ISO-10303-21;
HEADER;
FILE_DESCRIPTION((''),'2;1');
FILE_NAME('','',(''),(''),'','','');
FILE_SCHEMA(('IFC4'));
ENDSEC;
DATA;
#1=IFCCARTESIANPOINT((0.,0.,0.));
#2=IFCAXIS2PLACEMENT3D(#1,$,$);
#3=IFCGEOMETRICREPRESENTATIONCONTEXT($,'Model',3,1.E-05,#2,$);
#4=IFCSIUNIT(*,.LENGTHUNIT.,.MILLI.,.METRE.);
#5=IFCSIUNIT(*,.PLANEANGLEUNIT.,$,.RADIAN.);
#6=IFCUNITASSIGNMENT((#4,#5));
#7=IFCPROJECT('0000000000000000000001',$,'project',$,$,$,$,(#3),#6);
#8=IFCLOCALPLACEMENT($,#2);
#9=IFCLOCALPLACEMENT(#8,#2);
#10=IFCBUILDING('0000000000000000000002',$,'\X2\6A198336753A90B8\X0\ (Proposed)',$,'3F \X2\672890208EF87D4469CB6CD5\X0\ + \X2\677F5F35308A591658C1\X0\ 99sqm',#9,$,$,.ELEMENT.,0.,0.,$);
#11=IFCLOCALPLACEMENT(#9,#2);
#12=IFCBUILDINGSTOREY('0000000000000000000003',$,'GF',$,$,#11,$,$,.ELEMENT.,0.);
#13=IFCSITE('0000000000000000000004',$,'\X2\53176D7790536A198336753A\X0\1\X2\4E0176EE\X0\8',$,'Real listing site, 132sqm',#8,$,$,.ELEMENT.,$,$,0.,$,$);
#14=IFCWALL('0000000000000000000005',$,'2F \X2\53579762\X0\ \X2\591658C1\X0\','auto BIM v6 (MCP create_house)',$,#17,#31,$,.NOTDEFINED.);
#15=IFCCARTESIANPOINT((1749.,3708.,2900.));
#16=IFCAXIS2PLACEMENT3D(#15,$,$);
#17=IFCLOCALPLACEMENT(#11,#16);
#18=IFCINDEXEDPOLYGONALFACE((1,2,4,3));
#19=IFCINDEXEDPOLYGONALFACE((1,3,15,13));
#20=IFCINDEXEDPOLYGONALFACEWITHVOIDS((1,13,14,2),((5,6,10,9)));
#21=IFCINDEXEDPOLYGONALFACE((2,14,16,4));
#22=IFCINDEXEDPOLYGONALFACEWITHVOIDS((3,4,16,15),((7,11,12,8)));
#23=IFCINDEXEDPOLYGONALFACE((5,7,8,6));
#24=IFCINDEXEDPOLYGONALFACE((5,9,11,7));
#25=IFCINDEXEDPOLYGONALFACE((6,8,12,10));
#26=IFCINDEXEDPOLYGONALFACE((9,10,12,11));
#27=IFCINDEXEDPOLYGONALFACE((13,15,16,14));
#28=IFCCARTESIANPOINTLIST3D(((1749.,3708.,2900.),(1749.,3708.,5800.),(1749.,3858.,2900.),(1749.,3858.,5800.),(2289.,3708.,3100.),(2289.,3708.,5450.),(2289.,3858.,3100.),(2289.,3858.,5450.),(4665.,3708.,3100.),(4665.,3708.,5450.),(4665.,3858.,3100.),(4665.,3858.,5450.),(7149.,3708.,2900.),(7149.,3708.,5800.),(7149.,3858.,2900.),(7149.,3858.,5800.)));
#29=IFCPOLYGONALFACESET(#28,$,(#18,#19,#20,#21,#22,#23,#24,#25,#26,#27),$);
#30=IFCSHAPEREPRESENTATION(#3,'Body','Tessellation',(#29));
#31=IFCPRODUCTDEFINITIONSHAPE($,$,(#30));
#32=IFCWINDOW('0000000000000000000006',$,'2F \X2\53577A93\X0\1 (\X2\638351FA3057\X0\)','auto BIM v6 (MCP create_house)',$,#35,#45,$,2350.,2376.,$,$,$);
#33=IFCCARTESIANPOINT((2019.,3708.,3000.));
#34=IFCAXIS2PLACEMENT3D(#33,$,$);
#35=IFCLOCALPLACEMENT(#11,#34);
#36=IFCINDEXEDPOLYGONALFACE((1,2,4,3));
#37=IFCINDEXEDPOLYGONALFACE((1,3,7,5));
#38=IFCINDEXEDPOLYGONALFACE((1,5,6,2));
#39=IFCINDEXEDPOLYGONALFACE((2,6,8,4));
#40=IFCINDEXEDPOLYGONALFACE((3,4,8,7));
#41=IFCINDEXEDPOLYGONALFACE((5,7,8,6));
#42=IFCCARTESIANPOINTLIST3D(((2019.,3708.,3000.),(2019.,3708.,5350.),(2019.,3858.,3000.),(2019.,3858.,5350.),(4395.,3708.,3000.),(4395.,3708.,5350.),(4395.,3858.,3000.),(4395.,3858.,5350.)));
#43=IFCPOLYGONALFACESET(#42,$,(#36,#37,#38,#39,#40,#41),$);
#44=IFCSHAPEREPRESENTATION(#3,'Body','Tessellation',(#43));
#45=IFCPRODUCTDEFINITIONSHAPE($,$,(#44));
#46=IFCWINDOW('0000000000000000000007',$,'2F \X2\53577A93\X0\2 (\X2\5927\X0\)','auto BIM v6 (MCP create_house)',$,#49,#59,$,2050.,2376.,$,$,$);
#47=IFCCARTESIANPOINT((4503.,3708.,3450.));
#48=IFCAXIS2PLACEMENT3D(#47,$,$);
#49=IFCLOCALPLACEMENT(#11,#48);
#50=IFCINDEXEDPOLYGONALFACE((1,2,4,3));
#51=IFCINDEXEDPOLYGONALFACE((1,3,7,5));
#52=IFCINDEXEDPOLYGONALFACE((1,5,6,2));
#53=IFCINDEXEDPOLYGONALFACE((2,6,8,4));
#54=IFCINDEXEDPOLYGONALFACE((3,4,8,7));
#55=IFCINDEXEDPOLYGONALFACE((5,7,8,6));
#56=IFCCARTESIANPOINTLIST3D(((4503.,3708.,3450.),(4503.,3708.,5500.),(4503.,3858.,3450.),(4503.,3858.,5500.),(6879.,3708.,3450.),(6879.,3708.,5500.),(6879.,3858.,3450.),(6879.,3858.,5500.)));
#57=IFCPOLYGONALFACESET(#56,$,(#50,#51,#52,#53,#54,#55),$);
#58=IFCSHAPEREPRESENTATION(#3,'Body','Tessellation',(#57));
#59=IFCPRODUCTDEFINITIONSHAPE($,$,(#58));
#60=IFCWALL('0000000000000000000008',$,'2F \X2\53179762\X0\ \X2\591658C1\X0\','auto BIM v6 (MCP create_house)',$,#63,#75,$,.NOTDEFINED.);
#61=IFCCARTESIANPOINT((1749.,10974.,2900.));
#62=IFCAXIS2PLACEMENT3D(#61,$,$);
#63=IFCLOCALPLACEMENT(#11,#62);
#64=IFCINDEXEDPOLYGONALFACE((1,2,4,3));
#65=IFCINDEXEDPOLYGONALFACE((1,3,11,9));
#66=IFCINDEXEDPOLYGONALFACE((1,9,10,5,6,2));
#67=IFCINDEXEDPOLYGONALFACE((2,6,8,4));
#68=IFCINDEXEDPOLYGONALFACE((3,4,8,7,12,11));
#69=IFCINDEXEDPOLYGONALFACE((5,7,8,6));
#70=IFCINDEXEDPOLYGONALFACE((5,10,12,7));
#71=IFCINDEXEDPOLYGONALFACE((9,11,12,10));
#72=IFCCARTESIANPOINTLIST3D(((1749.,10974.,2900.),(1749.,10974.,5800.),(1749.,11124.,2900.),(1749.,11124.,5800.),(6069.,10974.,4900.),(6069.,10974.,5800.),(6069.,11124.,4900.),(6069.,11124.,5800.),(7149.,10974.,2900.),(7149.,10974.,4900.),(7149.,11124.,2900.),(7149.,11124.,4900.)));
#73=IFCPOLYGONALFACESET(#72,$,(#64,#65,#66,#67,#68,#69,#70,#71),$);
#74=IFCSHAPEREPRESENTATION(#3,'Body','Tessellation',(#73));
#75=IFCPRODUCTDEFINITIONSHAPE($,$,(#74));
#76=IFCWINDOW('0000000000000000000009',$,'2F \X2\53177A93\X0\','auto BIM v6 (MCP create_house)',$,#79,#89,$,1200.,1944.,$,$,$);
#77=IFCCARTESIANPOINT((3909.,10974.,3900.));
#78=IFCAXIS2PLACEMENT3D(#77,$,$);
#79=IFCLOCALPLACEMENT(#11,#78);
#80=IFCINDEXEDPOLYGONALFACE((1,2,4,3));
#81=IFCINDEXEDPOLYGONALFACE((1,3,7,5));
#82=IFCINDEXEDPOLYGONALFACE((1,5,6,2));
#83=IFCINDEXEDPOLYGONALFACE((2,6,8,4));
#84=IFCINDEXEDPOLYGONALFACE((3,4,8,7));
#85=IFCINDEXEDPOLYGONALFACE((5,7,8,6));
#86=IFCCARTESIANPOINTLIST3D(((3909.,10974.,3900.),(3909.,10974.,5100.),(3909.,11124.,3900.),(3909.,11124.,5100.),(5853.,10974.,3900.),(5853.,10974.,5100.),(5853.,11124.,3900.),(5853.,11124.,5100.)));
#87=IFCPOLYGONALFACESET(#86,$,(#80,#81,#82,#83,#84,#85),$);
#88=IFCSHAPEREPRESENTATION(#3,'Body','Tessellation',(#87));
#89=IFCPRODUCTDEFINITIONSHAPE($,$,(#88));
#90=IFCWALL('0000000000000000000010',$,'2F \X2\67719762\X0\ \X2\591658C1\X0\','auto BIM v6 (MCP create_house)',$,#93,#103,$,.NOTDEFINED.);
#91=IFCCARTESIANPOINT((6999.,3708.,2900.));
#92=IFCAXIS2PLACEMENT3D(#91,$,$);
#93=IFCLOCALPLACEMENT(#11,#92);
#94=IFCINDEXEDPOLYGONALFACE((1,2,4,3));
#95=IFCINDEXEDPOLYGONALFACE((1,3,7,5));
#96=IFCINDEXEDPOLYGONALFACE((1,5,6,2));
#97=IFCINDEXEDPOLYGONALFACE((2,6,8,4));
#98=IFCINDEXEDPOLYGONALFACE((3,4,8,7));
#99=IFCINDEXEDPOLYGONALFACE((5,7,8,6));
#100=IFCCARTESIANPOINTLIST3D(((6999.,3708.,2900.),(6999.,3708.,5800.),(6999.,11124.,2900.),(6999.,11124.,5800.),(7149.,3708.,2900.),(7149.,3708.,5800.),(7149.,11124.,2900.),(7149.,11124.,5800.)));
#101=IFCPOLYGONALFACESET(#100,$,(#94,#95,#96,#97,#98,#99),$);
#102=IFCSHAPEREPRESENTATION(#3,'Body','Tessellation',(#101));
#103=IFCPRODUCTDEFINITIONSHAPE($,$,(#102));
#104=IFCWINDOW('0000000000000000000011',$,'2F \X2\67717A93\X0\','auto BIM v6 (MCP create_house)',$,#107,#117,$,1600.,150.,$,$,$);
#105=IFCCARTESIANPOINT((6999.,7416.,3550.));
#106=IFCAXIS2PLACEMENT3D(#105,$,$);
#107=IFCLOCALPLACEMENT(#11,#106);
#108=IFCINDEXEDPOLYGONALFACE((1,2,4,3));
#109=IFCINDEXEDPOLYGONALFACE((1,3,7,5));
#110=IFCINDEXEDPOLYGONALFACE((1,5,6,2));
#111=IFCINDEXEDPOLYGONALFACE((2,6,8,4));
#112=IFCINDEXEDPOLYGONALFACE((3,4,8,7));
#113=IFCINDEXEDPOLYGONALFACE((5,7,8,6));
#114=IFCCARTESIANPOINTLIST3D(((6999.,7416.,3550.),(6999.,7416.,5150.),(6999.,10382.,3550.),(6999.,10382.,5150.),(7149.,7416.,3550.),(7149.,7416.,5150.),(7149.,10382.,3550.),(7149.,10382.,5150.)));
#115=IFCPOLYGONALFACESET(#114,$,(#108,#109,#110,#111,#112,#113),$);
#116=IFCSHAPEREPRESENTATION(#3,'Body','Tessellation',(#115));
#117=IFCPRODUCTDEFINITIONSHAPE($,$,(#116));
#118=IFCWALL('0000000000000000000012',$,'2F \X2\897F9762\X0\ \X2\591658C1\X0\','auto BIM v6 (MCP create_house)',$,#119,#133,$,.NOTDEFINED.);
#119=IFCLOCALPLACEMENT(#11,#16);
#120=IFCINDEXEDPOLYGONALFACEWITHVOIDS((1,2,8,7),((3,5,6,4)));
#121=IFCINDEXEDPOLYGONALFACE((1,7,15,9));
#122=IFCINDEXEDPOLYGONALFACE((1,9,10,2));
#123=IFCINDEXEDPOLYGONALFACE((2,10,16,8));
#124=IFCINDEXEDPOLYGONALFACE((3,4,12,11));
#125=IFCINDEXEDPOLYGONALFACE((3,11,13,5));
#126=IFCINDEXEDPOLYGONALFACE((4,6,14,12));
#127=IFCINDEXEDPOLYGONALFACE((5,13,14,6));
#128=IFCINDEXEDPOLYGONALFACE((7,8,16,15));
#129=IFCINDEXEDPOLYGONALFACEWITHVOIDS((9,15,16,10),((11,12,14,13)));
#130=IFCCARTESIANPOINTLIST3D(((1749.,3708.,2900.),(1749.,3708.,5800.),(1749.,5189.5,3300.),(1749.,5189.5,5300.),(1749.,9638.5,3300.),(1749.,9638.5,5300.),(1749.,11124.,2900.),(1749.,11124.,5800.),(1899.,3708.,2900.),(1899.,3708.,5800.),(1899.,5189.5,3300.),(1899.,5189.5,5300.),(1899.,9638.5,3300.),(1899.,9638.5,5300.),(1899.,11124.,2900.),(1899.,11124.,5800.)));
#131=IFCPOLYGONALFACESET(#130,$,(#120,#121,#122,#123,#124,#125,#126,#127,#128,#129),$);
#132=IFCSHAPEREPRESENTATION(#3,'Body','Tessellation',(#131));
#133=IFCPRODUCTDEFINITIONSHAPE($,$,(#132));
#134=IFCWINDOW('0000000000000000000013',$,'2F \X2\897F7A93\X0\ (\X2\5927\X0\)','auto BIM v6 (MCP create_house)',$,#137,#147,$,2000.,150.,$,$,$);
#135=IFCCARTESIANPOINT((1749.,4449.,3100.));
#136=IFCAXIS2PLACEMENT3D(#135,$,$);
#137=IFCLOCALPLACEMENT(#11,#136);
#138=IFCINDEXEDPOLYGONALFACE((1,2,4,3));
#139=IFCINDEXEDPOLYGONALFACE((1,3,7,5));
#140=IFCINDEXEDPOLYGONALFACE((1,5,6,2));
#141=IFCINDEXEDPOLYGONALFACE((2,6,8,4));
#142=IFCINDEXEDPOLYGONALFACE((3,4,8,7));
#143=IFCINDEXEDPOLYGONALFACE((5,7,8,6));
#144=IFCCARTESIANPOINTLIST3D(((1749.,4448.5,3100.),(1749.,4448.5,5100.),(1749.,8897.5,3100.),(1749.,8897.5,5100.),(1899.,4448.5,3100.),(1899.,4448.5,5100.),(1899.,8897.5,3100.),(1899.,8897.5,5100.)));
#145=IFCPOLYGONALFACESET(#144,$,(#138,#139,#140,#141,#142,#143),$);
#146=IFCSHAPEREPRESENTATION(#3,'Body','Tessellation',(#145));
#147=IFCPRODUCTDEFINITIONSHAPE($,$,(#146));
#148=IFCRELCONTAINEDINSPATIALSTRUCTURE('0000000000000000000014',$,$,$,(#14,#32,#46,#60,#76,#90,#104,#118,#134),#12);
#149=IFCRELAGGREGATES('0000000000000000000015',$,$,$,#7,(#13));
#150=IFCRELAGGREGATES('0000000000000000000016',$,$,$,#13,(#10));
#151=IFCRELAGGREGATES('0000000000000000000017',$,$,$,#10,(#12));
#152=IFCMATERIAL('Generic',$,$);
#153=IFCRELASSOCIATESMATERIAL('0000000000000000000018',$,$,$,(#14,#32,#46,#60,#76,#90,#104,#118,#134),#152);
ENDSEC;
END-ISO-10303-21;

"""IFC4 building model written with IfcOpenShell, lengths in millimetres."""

from ifc_helpers import new_model, si_unit, frame, frame_2d, origin, place, context, project, spatial, rectangle, extrude, material, element, fill, save


model = new_model("IFC4")

# Units and contexts
model_context = context("Model", 3, precision=1e-05, world=origin())
ifc_project = project(units=[si_unit("LENGTHUNIT", "METRE", prefix="MILLI"), si_unit("PLANEANGLEUNIT", "RADIAN")], contexts=[model_context])

# Site, building, storey
site_placement = place(None, origin())
site = spatial("IfcSite", under=ifc_project, at=site_placement, Name="北海道標茶町1丁目8", ObjectType="Real listing site, 132sqm", CompositionType="ELEMENT", RefElevation=0.0)
building_placement = place(site_placement, origin())
building = spatial("IfcBuilding", under=site, at=building_placement, Name="標茶町邸 (Proposed)", ObjectType="3F 木造軸組構法 + 板張り外壁 99sqm", CompositionType="ELEMENT", ElevationOfRefHeight=0.0, ElevationOfTerrain=0.0)
storey_placement = place(building_placement, origin())
storey = spatial("IfcBuildingStorey", under=building, at=storey_placement, Name="GF", CompositionType="ELEMENT", Elevation=0.0)

# Shared definitions
ifc_material = material(Name="Generic")

# Wall, openings, windows
wall_1_placement = place(storey_placement, frame((1749.0, 3708.0, 2900.0)))
wall_1 = element("IfcWall", 1, at=wall_1_placement, inside=storey, material=ifc_material, Name="2F 南面 外壁", Description="auto BIM v6 (MCP create_house)", PredefinedType="NOTDEFINED", context=model_context, shape_type="SweptSolid", body=[
    extrude(rectangle(XDim=5400.0, YDim=150.0, at=frame_2d((2700.0, 75.0))), frame((1749.0, 3708.0, 2900.0)), (0.0, 0.0, 1.0), 2900.0),
])
opening_1_placement = place(storey_placement, frame((2019.0, 3708.0, 3000.0)))
opening_1 = element("IfcOpeningElement", 2, at=opening_1_placement, cuts=wall_1, PredefinedType="NOTDEFINED", context=model_context, shape_type="SweptSolid", body=[
    extrude(rectangle(XDim=2376.0, YDim=150.0, at=frame_2d((1188.0, 75.0))), frame((2019.0, 3708.0, 3000.0)), (0.0, 0.0, 1.0), 2350.0),
])
opening_2_placement = place(storey_placement, frame((4503.0, 3708.0, 3450.0)))
opening_2 = element("IfcOpeningElement", 3, at=opening_2_placement, cuts=wall_1, PredefinedType="NOTDEFINED", context=model_context, shape_type="SweptSolid", body=[
    extrude(rectangle(XDim=2376.0, YDim=150.0, at=frame_2d((1188.0, 75.0))), frame((4503.0, 3708.0, 3450.0)), (0.0, 0.0, 1.0), 2050.0),
])
window_1_placement = place(storey_placement, frame((2019.0, 3708.0, 3000.0)))
window_1 = element("IfcWindow", 4, at=window_1_placement, inside=storey, material=ifc_material, Name="2F 南窓1 (掃出し)", Description="auto BIM v6 (MCP create_house)", OverallHeight=2350.0, OverallWidth=2376.0, context=model_context, shape_type="SweptSolid", body=[
    extrude(rectangle(XDim=2376.0, YDim=150.0, at=frame_2d((1188.0, 75.0))), frame((2019.0, 3708.0, 3000.0)), (0.0, 0.0, 1.0), 2350.0),
])
fill(opening_1, window_1)
window_2_placement = place(storey_placement, frame((4503.0, 3708.0, 3450.0)))
window_2 = element("IfcWindow", 5, at=window_2_placement, inside=storey, material=ifc_material, Name="2F 南窓2 (大)", Description="auto BIM v6 (MCP create_house)", OverallHeight=2050.0, OverallWidth=2376.0, context=model_context, shape_type="SweptSolid", body=[
    extrude(rectangle(XDim=2376.0, YDim=150.0, at=frame_2d((1188.0, 75.0))), frame((4503.0, 3708.0, 3450.0)), (0.0, 0.0, 1.0), 2050.0),
])
fill(opening_2, window_2)

# Walls, openings, windows
wall_2_placement = place(storey_placement, frame((1749.0, 10974.0, 2900.0)))
wall_2 = element("IfcWall", 6, at=wall_2_placement, inside=storey, material=ifc_material, Name="2F 北面 外壁", Description="auto BIM v6 (MCP create_house)", PredefinedType="NOTDEFINED", context=model_context, shape_type="SweptSolid", body=[
    extrude(rectangle(XDim=5400.0, YDim=150.0, at=frame_2d((2700.0, 75.0))), frame((1749.0, 10974.0, 2900.0)), (0.0, 0.0, 1.0), 2900.0),
])
opening_3_placement = place(storey_placement, frame((3909.0, 10974.0, 3900.0)))
opening_3 = element("IfcOpeningElement", 7, at=opening_3_placement, cuts=wall_2, PredefinedType="NOTDEFINED", context=model_context, shape_type="SweptSolid", body=[
    extrude(rectangle(XDim=1944.0, YDim=150.0, at=frame_2d((972.0, 75.0))), frame((3909.0, 10974.0, 3900.0)), (0.0, 0.0, 1.0), 1200.0),
])
window_3_placement = place(storey_placement, frame((3909.0, 10974.0, 3900.0)))
window_3 = element("IfcWindow", 8, at=window_3_placement, inside=storey, material=ifc_material, Name="2F 北窓", Description="auto BIM v6 (MCP create_house)", OverallHeight=1200.0, OverallWidth=1944.0, context=model_context, shape_type="SweptSolid", body=[
    extrude(rectangle(XDim=1944.0, YDim=150.0, at=frame_2d((972.0, 75.0))), frame((3909.0, 10974.0, 3900.0)), (0.0, 0.0, 1.0), 1200.0),
])
fill(opening_3, window_3)
wall_3_placement = place(storey_placement, frame((6999.0, 3708.0, 2900.0)))
wall_3 = element("IfcWall", 9, at=wall_3_placement, inside=storey, material=ifc_material, Name="2F 東面 外壁", Description="auto BIM v6 (MCP create_house)", PredefinedType="NOTDEFINED", context=model_context, shape_type="SweptSolid", body=[
    extrude(rectangle(XDim=150.0, YDim=7416.0, at=frame_2d((75.0, 3708.0))), frame((6999.0, 3708.0, 2900.0)), (0.0, 0.0, 1.0), 2900.0),
])
opening_4_placement = place(storey_placement, frame((6999.0, 7416.0, 3550.0)))
opening_4 = element("IfcOpeningElement", 10, at=opening_4_placement, cuts=wall_3, PredefinedType="NOTDEFINED", context=model_context, shape_type="SweptSolid", body=[
    extrude(rectangle(XDim=150.0, YDim=2966.0, at=frame_2d((75.0, 1483.0))), frame((6999.0, 7416.0, 3550.0)), (0.0, 0.0, 1.0), 1600.0),
])
window_4_placement = place(storey_placement, frame((6999.0, 7416.0, 3550.0)))
window_4 = element("IfcWindow", 11, at=window_4_placement, inside=storey, material=ifc_material, Name="2F 東窓", Description="auto BIM v6 (MCP create_house)", OverallHeight=1600.0, OverallWidth=150.0, context=model_context, shape_type="SweptSolid", body=[
    extrude(rectangle(XDim=150.0, YDim=2966.0, at=frame_2d((75.0, 1483.0))), frame((6999.0, 7416.0, 3550.0)), (0.0, 0.0, 1.0), 1600.0),
])
fill(opening_4, window_4)
wall_4_placement = place(storey_placement, frame((1749.0, 3708.0, 2900.0)))
wall_4 = element("IfcWall", 12, at=wall_4_placement, inside=storey, material=ifc_material, Name="2F 西面 外壁", Description="auto BIM v6 (MCP create_house)", PredefinedType="NOTDEFINED", context=model_context, shape_type="SweptSolid", body=[
    extrude(rectangle(XDim=150.0, YDim=7416.0, at=frame_2d((75.0, 3708.0))), frame((1749.0, 3708.0, 2900.0)), (0.0, 0.0, 1.0), 2900.0),
])
opening_5_placement = place(storey_placement, frame((1749.0, 4449.0, 3100.0)))
opening_5 = element("IfcOpeningElement", 13, at=opening_5_placement, cuts=wall_4, PredefinedType="NOTDEFINED", context=model_context, shape_type="SweptSolid", body=[
    extrude(rectangle(XDim=150.0, YDim=4449.0, at=frame_2d((75.0, 2224.0))), frame((1749.0, 4449.0, 3100.0)), (0.0, 0.0, 1.0), 2000.0),
])
window_5_placement = place(storey_placement, frame((1749.0, 4449.0, 3100.0)))
window_5 = element("IfcWindow", 14, at=window_5_placement, inside=storey, material=ifc_material, Name="2F 西窓 (大)", Description="auto BIM v6 (MCP create_house)", OverallHeight=2000.0, OverallWidth=150.0, context=model_context, shape_type="SweptSolid", body=[
    extrude(rectangle(XDim=150.0, YDim=4449.0, at=frame_2d((75.0, 2224.0))), frame((1749.0, 4449.0, 3100.0)), (0.0, 0.0, 1.0), 2000.0),
])
fill(opening_5, window_5)

save(model, "model.ifc")
